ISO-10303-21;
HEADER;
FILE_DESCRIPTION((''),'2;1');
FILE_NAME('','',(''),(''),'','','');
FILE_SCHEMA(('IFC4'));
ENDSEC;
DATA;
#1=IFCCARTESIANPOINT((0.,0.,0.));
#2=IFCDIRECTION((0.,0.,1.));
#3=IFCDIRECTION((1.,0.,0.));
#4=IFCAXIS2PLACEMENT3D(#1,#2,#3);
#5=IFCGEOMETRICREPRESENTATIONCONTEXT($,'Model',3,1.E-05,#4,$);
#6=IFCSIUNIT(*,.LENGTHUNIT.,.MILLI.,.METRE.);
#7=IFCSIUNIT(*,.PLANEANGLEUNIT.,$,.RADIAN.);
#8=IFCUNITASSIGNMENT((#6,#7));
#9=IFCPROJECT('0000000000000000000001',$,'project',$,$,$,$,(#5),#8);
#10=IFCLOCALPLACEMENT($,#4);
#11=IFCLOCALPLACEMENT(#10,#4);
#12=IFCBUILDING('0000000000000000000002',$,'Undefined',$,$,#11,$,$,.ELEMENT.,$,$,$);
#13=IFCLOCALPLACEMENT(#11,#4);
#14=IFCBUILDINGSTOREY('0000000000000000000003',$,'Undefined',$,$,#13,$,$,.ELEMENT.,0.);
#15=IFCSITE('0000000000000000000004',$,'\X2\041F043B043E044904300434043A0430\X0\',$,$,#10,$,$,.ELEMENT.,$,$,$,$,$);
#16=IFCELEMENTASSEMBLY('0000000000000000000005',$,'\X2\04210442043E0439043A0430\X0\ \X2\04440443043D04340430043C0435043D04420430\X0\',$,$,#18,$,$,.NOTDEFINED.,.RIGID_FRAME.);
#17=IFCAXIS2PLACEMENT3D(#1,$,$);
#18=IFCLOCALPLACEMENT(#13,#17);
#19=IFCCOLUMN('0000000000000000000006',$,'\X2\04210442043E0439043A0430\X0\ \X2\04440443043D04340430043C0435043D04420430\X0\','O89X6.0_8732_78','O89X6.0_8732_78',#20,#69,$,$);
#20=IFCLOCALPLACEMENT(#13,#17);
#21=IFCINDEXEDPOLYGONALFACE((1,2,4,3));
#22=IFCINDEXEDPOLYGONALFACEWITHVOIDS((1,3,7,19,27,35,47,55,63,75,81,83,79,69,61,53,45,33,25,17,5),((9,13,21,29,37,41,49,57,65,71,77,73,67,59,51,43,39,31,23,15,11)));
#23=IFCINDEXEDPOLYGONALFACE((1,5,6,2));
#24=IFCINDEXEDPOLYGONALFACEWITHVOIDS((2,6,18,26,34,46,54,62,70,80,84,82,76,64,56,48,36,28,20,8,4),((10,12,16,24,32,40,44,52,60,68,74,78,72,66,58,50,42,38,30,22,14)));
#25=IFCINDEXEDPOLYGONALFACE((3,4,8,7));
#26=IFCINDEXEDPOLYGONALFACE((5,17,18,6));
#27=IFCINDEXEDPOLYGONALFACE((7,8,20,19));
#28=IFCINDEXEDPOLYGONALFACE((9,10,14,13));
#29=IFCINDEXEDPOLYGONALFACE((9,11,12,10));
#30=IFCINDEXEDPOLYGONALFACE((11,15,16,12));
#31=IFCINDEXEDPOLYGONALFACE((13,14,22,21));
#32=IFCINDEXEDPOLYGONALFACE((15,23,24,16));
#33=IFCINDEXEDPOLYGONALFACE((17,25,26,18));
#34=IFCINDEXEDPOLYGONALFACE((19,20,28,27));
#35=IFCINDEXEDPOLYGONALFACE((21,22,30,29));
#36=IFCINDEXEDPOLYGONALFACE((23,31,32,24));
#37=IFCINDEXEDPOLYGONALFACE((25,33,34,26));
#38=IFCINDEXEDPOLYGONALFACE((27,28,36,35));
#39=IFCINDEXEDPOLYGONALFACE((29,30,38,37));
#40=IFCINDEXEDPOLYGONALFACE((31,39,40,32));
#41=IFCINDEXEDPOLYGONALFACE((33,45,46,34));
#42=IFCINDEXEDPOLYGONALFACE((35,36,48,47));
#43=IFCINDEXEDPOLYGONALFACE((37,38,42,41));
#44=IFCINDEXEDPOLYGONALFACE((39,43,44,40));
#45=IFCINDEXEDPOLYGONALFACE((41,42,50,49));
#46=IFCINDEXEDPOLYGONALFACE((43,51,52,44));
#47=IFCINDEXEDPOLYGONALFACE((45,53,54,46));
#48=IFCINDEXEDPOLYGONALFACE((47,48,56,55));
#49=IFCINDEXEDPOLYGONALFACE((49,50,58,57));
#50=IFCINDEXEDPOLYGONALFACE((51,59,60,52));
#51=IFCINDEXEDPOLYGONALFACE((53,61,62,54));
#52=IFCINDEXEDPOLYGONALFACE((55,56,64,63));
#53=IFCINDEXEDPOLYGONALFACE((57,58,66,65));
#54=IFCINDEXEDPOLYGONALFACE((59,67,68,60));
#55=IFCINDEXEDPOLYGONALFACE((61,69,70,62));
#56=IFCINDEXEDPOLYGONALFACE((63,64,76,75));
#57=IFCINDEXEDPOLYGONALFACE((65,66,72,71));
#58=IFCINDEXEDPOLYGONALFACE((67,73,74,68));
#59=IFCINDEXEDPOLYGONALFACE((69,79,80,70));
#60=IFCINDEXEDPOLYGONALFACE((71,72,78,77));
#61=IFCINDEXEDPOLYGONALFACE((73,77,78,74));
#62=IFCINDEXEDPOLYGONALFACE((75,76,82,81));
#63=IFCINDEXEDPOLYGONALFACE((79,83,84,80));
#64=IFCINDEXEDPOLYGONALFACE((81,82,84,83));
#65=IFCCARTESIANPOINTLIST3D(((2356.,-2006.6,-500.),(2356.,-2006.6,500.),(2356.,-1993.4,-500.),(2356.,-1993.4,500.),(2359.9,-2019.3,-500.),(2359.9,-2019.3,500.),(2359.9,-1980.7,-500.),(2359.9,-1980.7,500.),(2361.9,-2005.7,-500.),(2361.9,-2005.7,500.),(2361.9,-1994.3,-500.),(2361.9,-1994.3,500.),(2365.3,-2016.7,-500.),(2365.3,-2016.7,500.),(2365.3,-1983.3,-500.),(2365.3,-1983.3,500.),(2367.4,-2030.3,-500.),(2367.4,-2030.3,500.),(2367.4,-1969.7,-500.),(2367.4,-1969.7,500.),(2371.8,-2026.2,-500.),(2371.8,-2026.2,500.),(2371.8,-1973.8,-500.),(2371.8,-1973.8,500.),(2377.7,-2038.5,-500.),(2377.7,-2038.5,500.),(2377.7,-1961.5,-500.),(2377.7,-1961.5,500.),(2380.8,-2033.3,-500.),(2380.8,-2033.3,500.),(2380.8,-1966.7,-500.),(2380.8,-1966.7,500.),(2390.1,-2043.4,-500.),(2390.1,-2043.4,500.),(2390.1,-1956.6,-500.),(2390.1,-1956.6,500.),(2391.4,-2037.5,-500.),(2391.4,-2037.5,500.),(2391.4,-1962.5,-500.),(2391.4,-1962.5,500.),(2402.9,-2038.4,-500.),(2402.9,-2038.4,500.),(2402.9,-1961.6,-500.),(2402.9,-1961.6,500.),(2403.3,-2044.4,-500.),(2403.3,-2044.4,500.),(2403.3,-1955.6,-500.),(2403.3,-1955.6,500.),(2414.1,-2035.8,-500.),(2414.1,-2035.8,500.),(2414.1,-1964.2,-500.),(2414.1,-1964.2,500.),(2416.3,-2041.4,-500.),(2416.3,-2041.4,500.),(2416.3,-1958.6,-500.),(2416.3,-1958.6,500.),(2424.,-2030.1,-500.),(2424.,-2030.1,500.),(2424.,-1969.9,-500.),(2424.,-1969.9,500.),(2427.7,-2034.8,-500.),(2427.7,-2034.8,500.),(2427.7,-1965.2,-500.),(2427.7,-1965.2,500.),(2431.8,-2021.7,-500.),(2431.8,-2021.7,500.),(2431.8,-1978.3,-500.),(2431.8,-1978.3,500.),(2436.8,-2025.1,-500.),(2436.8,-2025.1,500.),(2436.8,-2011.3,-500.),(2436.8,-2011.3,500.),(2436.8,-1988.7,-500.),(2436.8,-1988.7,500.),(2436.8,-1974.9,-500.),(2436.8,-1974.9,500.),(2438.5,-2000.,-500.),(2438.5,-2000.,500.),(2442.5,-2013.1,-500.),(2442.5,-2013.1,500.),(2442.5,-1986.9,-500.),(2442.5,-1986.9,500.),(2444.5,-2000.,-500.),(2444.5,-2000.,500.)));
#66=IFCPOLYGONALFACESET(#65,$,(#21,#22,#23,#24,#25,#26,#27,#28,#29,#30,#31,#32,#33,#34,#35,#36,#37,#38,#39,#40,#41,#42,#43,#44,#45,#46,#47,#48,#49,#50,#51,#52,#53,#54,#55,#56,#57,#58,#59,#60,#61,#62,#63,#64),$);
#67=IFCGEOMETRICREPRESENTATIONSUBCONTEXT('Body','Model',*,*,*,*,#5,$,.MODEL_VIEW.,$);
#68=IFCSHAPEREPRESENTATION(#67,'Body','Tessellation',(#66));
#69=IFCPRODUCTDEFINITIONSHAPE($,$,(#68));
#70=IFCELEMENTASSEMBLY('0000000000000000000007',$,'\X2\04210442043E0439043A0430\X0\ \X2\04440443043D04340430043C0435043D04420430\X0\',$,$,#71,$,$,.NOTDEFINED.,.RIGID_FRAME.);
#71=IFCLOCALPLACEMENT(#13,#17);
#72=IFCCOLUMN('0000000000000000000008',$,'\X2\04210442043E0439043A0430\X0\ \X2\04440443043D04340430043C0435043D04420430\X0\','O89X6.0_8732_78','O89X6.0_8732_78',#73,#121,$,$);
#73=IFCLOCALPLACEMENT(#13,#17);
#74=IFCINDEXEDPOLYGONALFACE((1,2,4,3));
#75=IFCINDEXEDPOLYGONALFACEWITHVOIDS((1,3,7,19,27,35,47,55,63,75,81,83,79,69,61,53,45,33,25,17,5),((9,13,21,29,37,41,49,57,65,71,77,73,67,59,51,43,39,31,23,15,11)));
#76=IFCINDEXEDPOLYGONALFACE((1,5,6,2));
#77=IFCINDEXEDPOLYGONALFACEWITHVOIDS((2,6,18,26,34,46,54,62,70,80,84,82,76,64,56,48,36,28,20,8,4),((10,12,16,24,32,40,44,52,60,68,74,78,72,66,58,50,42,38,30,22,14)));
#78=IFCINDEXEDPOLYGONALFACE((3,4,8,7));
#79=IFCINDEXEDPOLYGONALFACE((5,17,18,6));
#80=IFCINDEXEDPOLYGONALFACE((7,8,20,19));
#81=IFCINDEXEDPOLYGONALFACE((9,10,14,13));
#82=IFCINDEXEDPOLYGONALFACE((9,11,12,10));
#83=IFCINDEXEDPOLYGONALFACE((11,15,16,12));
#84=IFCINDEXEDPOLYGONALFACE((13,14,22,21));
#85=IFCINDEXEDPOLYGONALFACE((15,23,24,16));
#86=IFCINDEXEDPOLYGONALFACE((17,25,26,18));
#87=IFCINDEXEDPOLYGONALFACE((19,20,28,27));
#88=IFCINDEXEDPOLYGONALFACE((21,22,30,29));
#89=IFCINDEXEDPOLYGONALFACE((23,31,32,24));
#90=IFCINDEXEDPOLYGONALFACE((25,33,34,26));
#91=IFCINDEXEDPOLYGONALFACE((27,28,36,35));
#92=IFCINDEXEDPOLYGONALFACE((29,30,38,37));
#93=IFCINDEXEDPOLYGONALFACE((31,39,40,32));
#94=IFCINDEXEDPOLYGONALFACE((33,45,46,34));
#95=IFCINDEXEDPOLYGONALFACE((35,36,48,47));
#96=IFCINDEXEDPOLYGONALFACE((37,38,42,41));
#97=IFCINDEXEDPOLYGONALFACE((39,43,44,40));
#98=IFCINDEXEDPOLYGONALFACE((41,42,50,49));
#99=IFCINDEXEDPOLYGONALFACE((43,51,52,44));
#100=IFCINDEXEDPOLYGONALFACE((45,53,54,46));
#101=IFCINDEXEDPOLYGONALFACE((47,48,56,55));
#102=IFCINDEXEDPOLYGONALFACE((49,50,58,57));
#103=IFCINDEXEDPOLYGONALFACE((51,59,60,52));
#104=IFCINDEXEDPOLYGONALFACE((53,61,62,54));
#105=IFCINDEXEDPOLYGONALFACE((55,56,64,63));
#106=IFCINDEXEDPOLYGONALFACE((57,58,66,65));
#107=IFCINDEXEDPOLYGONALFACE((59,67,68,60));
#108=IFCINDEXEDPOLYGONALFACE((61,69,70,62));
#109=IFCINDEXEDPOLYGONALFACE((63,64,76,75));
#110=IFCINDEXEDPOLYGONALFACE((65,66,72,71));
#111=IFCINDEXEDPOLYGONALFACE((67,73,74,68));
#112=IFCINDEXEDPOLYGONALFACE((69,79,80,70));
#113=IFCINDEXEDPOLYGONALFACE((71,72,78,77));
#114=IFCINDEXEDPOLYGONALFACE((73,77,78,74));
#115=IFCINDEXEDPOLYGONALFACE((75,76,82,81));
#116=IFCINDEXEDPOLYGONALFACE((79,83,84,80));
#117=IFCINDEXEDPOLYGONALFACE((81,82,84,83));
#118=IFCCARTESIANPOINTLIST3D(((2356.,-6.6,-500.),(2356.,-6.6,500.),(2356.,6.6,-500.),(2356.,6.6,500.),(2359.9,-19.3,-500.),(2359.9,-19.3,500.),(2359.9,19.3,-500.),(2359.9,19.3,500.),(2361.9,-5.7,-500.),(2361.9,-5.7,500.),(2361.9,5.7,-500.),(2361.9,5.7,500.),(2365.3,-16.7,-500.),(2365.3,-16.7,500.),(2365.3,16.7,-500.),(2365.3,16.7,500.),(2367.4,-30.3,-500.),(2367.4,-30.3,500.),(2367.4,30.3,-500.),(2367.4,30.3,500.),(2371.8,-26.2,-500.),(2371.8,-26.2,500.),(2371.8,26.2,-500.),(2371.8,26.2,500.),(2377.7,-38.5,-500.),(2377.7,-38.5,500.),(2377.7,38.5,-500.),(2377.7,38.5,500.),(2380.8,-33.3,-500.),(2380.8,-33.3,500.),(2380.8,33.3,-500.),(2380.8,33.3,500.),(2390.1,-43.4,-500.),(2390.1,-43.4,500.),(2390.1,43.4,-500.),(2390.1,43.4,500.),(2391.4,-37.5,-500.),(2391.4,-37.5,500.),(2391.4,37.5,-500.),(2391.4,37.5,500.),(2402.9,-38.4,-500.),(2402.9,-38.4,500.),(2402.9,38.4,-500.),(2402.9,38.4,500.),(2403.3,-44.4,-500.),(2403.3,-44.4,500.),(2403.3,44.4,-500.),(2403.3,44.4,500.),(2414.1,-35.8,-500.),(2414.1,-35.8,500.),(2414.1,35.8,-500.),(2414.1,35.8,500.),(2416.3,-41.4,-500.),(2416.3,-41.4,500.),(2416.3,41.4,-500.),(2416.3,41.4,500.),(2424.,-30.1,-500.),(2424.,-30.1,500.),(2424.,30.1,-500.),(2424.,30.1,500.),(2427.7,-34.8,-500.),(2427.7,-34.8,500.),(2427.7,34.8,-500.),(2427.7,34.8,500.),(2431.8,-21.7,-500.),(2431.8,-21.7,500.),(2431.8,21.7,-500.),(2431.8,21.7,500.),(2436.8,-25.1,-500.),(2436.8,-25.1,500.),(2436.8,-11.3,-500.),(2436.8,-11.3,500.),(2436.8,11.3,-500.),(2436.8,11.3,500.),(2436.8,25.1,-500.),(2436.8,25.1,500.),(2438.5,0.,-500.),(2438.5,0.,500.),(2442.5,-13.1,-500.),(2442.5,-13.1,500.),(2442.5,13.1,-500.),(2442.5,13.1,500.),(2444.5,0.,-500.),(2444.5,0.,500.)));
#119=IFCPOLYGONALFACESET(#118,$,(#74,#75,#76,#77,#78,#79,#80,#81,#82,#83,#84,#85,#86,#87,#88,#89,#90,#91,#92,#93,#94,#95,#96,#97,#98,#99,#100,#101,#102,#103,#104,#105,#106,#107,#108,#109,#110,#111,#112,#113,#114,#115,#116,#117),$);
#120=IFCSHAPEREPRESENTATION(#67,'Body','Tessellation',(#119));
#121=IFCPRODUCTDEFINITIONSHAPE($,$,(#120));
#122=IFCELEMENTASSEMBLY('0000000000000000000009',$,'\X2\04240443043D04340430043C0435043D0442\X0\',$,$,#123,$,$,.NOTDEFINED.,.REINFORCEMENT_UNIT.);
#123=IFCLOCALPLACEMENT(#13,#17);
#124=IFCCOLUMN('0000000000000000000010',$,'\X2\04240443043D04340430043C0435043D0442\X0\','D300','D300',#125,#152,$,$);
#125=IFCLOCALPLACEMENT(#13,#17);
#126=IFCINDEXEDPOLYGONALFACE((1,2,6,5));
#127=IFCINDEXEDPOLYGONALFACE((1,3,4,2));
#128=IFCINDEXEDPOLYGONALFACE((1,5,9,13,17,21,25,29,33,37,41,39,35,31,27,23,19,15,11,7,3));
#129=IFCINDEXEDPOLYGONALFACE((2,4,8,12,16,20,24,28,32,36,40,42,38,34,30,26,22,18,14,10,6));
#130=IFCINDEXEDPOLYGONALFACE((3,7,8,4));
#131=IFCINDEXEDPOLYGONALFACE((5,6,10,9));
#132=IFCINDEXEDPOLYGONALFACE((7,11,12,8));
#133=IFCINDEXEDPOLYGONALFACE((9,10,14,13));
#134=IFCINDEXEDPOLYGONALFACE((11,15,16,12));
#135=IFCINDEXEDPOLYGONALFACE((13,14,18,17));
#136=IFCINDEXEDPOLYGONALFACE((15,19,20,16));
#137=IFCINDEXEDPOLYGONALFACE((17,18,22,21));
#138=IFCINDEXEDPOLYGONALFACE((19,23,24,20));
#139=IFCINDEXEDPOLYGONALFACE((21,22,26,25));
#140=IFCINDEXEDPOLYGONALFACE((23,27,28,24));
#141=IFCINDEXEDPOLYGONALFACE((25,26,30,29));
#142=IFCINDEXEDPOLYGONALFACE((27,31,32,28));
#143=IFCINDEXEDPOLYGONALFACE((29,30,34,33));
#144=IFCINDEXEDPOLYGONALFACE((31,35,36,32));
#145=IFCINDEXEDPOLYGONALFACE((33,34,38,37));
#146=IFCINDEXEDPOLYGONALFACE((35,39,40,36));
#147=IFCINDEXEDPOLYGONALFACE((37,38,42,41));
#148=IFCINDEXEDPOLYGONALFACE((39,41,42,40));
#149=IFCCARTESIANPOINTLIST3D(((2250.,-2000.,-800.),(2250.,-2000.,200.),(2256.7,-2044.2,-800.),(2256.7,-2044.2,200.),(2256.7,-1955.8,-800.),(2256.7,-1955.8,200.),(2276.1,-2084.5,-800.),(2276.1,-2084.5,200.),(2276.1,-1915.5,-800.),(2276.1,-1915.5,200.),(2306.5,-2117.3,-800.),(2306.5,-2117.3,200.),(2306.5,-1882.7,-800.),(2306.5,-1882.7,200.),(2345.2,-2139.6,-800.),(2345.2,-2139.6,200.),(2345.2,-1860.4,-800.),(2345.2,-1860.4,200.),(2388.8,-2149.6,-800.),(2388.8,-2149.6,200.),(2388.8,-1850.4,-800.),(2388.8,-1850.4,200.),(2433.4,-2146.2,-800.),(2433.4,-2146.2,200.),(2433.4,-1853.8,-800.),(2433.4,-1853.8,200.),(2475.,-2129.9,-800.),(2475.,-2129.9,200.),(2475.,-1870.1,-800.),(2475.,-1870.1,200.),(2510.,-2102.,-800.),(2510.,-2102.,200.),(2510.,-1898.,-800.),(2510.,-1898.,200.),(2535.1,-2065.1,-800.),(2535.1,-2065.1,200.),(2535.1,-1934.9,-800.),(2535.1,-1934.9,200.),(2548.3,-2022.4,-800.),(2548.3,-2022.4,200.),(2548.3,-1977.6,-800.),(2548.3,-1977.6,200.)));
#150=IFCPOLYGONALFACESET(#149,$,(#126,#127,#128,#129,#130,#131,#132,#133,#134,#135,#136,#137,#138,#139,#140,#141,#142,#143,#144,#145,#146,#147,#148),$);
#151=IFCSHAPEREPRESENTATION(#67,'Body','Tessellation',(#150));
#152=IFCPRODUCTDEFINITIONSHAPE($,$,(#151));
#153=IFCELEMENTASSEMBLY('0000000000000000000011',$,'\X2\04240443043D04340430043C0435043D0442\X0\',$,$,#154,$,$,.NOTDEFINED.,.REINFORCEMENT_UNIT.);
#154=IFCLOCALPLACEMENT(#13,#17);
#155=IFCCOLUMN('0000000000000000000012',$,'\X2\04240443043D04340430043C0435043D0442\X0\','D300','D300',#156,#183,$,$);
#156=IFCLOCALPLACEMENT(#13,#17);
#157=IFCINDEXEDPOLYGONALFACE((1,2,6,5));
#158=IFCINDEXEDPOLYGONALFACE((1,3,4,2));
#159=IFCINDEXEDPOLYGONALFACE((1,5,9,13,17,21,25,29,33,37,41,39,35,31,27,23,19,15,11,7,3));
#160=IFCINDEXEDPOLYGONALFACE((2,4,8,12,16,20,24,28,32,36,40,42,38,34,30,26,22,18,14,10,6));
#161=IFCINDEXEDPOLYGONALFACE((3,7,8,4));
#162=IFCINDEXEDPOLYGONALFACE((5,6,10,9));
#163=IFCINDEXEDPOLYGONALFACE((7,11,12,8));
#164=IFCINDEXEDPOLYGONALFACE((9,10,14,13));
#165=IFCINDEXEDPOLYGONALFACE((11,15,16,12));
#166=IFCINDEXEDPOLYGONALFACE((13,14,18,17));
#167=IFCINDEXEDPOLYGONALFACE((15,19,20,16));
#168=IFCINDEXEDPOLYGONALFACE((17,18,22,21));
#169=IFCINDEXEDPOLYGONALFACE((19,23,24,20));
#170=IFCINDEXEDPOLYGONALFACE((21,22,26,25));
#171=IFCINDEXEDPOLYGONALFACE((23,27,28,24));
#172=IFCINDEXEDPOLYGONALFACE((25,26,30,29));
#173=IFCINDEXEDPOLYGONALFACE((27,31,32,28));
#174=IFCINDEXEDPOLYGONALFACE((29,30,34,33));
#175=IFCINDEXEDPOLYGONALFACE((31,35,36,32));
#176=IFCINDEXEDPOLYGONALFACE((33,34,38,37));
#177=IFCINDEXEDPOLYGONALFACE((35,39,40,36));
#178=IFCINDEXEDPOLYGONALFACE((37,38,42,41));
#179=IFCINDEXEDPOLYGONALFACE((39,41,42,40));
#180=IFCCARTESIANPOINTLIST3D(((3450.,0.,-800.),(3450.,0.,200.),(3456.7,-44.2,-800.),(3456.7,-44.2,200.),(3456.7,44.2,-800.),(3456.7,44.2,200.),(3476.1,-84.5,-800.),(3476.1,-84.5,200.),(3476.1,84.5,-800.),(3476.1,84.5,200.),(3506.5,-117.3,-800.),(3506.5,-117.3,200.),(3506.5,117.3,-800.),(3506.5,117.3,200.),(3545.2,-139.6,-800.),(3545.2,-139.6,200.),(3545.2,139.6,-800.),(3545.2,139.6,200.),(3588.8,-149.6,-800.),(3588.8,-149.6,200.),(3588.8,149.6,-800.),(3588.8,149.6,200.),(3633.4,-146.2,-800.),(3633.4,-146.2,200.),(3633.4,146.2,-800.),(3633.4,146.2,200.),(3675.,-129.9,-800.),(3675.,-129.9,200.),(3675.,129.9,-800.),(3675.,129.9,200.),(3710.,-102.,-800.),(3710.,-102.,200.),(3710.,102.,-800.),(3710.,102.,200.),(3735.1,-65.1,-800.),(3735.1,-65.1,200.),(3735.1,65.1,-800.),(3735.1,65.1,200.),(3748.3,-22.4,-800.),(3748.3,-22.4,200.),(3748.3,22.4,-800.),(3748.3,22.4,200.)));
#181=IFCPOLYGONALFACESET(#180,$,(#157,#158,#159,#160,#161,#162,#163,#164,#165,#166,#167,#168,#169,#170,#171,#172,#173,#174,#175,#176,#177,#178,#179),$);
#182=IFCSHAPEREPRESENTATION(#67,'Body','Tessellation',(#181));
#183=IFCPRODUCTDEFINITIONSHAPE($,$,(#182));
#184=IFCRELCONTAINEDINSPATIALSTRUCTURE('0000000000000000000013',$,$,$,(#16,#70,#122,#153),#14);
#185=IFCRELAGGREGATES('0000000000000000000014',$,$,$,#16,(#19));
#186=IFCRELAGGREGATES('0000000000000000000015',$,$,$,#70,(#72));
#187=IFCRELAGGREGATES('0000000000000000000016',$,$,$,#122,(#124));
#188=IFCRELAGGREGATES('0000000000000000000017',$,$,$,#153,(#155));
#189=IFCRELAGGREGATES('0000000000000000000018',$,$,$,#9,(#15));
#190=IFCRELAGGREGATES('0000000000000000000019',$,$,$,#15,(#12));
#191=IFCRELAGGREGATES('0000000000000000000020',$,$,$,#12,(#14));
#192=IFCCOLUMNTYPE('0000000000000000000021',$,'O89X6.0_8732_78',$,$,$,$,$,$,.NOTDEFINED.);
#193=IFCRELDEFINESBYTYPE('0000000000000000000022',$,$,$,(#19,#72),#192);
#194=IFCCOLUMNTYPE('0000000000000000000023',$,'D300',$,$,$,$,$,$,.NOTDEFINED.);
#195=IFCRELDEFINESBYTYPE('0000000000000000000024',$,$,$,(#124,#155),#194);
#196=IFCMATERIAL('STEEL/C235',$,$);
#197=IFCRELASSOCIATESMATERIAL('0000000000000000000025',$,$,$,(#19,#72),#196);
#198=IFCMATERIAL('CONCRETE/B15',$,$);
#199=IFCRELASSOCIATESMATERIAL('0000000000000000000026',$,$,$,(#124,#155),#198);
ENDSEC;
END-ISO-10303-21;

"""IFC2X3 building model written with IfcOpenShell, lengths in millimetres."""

from ifc_helpers import new_model, si_unit, frame, origin_with_axes, origin_2d_with_axis, place, context, subcontext, project, spatial, circle, hollow_circle, extrude, material, type_object, element, aggregate, save


model = new_model("IFC2X3")

# Units and contexts
model_context = context("Model", 3, precision=1e-05, world=origin_with_axes())
body_context = subcontext(model_context, "Body", "Model", "MODEL_VIEW")
ifc_project = project(units=[si_unit("LENGTHUNIT", "METRE", prefix="MILLI"), si_unit("PLANEANGLEUNIT", "RADIAN")], contexts=[model_context])

# Site, building, storey
site_placement = place(None, origin_with_axes())
site = spatial("IfcSite", under=ifc_project, at=site_placement, Name="Площадка", CompositionType="ELEMENT")
building_placement = place(site_placement, origin_with_axes())
building = spatial("IfcBuilding", under=site, at=building_placement, Name="Undefined", CompositionType="ELEMENT")
storey_placement = place(building_placement, origin_with_axes())
storey = spatial("IfcBuildingStorey", under=building, at=storey_placement, Name="Undefined", CompositionType="ELEMENT", Elevation=0.0)

# Element assemblies, columns
assembly_1_placement = place(storey_placement, origin_with_axes())
assembly_1 = element("IfcElementAssembly", 1, at=assembly_1_placement, inside=storey, Name="Стойка фундамента", AssemblyPlace="NOTDEFINED", PredefinedType="RIGID_FRAME")
ifc_material_1 = material(Name="STEEL/C235")
column_type_1 = type_object("IfcColumnType", Name="O89X6.0_8732_78", PredefinedType="NOTDEFINED")
column_1_placement = place(assembly_1_placement, frame((2400.0, -2000.0, -500.0), z_axis=(0.0, 0.0, 1.0), x_axis=(0.0, -1.0, 0.0)))
column_1 = element("IfcColumn", 2, at=column_1_placement, type_object=column_type_1, material=ifc_material_1, Name="Стойка фундамента", Description="O89X6.0_8732_78", ObjectType="O89X6.0_8732_78", context=body_context, shape_type="SweptSolid", body=[
    extrude(hollow_circle(Radius=44.5, WallThickness=6.0, at=origin_2d_with_axis()), frame((0.0, 0.0, 1000.0), z_axis=(0.0, 0.0, -1.0), x_axis=(0.0, 1.0, 0.0)), (0.0, 0.0, 1.0), 1000.0),
])
assembly_2_placement = place(storey_placement, origin_with_axes())
assembly_2 = element("IfcElementAssembly", 3, at=assembly_2_placement, inside=storey, Name="Стойка фундамента", AssemblyPlace="NOTDEFINED", PredefinedType="RIGID_FRAME")
column_2_placement = place(assembly_2_placement, frame((2400.0, 0.0, -500.0), z_axis=(0.0, 0.0, 1.0), x_axis=(0.0, -1.0, 0.0)))
column_2 = element("IfcColumn", 4, at=column_2_placement, type_object=column_type_1, material=ifc_material_1, Name="Стойка фундамента", Description="O89X6.0_8732_78", ObjectType="O89X6.0_8732_78", context=body_context, shape_type="SweptSolid", body=[
    extrude(hollow_circle(Radius=44.5, WallThickness=6.0, at=origin_2d_with_axis()), frame((0.0, 0.0, 1000.0), z_axis=(0.0, 0.0, -1.0), x_axis=(0.0, 1.0, 0.0)), (0.0, 0.0, 1.0), 1000.0),
])
assembly_3_placement = place(storey_placement, origin_with_axes())
assembly_3 = element("IfcElementAssembly", 5, at=assembly_3_placement, inside=storey, Name="Фундамент", AssemblyPlace="NOTDEFINED", PredefinedType="REINFORCEMENT_UNIT")
ifc_material_2 = material(Name="CONCRETE/B15")
column_type_2 = type_object("IfcColumnType", Name="D300", PredefinedType="NOTDEFINED")
column_3_placement = place(assembly_3_placement, frame((2400.0, -2000.0, -800.0), z_axis=(0.0, 0.0, 1.0), x_axis=(0.0, 1.0, 0.0)))
column_3 = element("IfcColumn", 6, at=column_3_placement, type_object=column_type_2, material=ifc_material_2, Name="Фундамент", Description="D300", ObjectType="D300", context=body_context, shape_type="SweptSolid", body=[
    extrude(circle(Radius=150.0, at=origin_2d_with_axis()), frame((0.0, 0.0, 1000.0), z_axis=(0.0, 0.0, -1.0), x_axis=(0.0, 1.0, 0.0)), (0.0, 0.0, 1.0), 1000.0),
])
assembly_4_placement = place(storey_placement, origin_with_axes())
assembly_4 = element("IfcElementAssembly", 7, at=assembly_4_placement, inside=storey, Name="Фундамент", AssemblyPlace="NOTDEFINED", PredefinedType="REINFORCEMENT_UNIT")
column_4_placement = place(assembly_4_placement, frame((3600.0, 0.0, -800.0), z_axis=(0.0, 0.0, 1.0), x_axis=(0.0, 1.0, 0.0)))
column_4 = element("IfcColumn", 8, at=column_4_placement, type_object=column_type_2, material=ifc_material_2, Name="Фундамент", Description="D300", ObjectType="D300", context=body_context, shape_type="SweptSolid", body=[
    extrude(circle(Radius=150.0, at=origin_2d_with_axis()), frame((0.0, 0.0, 1000.0), z_axis=(0.0, 0.0, -1.0), x_axis=(0.0, 1.0, 0.0)), (0.0, 0.0, 1.0), 1000.0),
])

aggregate(assembly_1, [column_1])
aggregate(assembly_2, [column_2])

aggregate(assembly_3, [column_3])
aggregate(assembly_4, [column_4])

save(model, "model.ifc")
